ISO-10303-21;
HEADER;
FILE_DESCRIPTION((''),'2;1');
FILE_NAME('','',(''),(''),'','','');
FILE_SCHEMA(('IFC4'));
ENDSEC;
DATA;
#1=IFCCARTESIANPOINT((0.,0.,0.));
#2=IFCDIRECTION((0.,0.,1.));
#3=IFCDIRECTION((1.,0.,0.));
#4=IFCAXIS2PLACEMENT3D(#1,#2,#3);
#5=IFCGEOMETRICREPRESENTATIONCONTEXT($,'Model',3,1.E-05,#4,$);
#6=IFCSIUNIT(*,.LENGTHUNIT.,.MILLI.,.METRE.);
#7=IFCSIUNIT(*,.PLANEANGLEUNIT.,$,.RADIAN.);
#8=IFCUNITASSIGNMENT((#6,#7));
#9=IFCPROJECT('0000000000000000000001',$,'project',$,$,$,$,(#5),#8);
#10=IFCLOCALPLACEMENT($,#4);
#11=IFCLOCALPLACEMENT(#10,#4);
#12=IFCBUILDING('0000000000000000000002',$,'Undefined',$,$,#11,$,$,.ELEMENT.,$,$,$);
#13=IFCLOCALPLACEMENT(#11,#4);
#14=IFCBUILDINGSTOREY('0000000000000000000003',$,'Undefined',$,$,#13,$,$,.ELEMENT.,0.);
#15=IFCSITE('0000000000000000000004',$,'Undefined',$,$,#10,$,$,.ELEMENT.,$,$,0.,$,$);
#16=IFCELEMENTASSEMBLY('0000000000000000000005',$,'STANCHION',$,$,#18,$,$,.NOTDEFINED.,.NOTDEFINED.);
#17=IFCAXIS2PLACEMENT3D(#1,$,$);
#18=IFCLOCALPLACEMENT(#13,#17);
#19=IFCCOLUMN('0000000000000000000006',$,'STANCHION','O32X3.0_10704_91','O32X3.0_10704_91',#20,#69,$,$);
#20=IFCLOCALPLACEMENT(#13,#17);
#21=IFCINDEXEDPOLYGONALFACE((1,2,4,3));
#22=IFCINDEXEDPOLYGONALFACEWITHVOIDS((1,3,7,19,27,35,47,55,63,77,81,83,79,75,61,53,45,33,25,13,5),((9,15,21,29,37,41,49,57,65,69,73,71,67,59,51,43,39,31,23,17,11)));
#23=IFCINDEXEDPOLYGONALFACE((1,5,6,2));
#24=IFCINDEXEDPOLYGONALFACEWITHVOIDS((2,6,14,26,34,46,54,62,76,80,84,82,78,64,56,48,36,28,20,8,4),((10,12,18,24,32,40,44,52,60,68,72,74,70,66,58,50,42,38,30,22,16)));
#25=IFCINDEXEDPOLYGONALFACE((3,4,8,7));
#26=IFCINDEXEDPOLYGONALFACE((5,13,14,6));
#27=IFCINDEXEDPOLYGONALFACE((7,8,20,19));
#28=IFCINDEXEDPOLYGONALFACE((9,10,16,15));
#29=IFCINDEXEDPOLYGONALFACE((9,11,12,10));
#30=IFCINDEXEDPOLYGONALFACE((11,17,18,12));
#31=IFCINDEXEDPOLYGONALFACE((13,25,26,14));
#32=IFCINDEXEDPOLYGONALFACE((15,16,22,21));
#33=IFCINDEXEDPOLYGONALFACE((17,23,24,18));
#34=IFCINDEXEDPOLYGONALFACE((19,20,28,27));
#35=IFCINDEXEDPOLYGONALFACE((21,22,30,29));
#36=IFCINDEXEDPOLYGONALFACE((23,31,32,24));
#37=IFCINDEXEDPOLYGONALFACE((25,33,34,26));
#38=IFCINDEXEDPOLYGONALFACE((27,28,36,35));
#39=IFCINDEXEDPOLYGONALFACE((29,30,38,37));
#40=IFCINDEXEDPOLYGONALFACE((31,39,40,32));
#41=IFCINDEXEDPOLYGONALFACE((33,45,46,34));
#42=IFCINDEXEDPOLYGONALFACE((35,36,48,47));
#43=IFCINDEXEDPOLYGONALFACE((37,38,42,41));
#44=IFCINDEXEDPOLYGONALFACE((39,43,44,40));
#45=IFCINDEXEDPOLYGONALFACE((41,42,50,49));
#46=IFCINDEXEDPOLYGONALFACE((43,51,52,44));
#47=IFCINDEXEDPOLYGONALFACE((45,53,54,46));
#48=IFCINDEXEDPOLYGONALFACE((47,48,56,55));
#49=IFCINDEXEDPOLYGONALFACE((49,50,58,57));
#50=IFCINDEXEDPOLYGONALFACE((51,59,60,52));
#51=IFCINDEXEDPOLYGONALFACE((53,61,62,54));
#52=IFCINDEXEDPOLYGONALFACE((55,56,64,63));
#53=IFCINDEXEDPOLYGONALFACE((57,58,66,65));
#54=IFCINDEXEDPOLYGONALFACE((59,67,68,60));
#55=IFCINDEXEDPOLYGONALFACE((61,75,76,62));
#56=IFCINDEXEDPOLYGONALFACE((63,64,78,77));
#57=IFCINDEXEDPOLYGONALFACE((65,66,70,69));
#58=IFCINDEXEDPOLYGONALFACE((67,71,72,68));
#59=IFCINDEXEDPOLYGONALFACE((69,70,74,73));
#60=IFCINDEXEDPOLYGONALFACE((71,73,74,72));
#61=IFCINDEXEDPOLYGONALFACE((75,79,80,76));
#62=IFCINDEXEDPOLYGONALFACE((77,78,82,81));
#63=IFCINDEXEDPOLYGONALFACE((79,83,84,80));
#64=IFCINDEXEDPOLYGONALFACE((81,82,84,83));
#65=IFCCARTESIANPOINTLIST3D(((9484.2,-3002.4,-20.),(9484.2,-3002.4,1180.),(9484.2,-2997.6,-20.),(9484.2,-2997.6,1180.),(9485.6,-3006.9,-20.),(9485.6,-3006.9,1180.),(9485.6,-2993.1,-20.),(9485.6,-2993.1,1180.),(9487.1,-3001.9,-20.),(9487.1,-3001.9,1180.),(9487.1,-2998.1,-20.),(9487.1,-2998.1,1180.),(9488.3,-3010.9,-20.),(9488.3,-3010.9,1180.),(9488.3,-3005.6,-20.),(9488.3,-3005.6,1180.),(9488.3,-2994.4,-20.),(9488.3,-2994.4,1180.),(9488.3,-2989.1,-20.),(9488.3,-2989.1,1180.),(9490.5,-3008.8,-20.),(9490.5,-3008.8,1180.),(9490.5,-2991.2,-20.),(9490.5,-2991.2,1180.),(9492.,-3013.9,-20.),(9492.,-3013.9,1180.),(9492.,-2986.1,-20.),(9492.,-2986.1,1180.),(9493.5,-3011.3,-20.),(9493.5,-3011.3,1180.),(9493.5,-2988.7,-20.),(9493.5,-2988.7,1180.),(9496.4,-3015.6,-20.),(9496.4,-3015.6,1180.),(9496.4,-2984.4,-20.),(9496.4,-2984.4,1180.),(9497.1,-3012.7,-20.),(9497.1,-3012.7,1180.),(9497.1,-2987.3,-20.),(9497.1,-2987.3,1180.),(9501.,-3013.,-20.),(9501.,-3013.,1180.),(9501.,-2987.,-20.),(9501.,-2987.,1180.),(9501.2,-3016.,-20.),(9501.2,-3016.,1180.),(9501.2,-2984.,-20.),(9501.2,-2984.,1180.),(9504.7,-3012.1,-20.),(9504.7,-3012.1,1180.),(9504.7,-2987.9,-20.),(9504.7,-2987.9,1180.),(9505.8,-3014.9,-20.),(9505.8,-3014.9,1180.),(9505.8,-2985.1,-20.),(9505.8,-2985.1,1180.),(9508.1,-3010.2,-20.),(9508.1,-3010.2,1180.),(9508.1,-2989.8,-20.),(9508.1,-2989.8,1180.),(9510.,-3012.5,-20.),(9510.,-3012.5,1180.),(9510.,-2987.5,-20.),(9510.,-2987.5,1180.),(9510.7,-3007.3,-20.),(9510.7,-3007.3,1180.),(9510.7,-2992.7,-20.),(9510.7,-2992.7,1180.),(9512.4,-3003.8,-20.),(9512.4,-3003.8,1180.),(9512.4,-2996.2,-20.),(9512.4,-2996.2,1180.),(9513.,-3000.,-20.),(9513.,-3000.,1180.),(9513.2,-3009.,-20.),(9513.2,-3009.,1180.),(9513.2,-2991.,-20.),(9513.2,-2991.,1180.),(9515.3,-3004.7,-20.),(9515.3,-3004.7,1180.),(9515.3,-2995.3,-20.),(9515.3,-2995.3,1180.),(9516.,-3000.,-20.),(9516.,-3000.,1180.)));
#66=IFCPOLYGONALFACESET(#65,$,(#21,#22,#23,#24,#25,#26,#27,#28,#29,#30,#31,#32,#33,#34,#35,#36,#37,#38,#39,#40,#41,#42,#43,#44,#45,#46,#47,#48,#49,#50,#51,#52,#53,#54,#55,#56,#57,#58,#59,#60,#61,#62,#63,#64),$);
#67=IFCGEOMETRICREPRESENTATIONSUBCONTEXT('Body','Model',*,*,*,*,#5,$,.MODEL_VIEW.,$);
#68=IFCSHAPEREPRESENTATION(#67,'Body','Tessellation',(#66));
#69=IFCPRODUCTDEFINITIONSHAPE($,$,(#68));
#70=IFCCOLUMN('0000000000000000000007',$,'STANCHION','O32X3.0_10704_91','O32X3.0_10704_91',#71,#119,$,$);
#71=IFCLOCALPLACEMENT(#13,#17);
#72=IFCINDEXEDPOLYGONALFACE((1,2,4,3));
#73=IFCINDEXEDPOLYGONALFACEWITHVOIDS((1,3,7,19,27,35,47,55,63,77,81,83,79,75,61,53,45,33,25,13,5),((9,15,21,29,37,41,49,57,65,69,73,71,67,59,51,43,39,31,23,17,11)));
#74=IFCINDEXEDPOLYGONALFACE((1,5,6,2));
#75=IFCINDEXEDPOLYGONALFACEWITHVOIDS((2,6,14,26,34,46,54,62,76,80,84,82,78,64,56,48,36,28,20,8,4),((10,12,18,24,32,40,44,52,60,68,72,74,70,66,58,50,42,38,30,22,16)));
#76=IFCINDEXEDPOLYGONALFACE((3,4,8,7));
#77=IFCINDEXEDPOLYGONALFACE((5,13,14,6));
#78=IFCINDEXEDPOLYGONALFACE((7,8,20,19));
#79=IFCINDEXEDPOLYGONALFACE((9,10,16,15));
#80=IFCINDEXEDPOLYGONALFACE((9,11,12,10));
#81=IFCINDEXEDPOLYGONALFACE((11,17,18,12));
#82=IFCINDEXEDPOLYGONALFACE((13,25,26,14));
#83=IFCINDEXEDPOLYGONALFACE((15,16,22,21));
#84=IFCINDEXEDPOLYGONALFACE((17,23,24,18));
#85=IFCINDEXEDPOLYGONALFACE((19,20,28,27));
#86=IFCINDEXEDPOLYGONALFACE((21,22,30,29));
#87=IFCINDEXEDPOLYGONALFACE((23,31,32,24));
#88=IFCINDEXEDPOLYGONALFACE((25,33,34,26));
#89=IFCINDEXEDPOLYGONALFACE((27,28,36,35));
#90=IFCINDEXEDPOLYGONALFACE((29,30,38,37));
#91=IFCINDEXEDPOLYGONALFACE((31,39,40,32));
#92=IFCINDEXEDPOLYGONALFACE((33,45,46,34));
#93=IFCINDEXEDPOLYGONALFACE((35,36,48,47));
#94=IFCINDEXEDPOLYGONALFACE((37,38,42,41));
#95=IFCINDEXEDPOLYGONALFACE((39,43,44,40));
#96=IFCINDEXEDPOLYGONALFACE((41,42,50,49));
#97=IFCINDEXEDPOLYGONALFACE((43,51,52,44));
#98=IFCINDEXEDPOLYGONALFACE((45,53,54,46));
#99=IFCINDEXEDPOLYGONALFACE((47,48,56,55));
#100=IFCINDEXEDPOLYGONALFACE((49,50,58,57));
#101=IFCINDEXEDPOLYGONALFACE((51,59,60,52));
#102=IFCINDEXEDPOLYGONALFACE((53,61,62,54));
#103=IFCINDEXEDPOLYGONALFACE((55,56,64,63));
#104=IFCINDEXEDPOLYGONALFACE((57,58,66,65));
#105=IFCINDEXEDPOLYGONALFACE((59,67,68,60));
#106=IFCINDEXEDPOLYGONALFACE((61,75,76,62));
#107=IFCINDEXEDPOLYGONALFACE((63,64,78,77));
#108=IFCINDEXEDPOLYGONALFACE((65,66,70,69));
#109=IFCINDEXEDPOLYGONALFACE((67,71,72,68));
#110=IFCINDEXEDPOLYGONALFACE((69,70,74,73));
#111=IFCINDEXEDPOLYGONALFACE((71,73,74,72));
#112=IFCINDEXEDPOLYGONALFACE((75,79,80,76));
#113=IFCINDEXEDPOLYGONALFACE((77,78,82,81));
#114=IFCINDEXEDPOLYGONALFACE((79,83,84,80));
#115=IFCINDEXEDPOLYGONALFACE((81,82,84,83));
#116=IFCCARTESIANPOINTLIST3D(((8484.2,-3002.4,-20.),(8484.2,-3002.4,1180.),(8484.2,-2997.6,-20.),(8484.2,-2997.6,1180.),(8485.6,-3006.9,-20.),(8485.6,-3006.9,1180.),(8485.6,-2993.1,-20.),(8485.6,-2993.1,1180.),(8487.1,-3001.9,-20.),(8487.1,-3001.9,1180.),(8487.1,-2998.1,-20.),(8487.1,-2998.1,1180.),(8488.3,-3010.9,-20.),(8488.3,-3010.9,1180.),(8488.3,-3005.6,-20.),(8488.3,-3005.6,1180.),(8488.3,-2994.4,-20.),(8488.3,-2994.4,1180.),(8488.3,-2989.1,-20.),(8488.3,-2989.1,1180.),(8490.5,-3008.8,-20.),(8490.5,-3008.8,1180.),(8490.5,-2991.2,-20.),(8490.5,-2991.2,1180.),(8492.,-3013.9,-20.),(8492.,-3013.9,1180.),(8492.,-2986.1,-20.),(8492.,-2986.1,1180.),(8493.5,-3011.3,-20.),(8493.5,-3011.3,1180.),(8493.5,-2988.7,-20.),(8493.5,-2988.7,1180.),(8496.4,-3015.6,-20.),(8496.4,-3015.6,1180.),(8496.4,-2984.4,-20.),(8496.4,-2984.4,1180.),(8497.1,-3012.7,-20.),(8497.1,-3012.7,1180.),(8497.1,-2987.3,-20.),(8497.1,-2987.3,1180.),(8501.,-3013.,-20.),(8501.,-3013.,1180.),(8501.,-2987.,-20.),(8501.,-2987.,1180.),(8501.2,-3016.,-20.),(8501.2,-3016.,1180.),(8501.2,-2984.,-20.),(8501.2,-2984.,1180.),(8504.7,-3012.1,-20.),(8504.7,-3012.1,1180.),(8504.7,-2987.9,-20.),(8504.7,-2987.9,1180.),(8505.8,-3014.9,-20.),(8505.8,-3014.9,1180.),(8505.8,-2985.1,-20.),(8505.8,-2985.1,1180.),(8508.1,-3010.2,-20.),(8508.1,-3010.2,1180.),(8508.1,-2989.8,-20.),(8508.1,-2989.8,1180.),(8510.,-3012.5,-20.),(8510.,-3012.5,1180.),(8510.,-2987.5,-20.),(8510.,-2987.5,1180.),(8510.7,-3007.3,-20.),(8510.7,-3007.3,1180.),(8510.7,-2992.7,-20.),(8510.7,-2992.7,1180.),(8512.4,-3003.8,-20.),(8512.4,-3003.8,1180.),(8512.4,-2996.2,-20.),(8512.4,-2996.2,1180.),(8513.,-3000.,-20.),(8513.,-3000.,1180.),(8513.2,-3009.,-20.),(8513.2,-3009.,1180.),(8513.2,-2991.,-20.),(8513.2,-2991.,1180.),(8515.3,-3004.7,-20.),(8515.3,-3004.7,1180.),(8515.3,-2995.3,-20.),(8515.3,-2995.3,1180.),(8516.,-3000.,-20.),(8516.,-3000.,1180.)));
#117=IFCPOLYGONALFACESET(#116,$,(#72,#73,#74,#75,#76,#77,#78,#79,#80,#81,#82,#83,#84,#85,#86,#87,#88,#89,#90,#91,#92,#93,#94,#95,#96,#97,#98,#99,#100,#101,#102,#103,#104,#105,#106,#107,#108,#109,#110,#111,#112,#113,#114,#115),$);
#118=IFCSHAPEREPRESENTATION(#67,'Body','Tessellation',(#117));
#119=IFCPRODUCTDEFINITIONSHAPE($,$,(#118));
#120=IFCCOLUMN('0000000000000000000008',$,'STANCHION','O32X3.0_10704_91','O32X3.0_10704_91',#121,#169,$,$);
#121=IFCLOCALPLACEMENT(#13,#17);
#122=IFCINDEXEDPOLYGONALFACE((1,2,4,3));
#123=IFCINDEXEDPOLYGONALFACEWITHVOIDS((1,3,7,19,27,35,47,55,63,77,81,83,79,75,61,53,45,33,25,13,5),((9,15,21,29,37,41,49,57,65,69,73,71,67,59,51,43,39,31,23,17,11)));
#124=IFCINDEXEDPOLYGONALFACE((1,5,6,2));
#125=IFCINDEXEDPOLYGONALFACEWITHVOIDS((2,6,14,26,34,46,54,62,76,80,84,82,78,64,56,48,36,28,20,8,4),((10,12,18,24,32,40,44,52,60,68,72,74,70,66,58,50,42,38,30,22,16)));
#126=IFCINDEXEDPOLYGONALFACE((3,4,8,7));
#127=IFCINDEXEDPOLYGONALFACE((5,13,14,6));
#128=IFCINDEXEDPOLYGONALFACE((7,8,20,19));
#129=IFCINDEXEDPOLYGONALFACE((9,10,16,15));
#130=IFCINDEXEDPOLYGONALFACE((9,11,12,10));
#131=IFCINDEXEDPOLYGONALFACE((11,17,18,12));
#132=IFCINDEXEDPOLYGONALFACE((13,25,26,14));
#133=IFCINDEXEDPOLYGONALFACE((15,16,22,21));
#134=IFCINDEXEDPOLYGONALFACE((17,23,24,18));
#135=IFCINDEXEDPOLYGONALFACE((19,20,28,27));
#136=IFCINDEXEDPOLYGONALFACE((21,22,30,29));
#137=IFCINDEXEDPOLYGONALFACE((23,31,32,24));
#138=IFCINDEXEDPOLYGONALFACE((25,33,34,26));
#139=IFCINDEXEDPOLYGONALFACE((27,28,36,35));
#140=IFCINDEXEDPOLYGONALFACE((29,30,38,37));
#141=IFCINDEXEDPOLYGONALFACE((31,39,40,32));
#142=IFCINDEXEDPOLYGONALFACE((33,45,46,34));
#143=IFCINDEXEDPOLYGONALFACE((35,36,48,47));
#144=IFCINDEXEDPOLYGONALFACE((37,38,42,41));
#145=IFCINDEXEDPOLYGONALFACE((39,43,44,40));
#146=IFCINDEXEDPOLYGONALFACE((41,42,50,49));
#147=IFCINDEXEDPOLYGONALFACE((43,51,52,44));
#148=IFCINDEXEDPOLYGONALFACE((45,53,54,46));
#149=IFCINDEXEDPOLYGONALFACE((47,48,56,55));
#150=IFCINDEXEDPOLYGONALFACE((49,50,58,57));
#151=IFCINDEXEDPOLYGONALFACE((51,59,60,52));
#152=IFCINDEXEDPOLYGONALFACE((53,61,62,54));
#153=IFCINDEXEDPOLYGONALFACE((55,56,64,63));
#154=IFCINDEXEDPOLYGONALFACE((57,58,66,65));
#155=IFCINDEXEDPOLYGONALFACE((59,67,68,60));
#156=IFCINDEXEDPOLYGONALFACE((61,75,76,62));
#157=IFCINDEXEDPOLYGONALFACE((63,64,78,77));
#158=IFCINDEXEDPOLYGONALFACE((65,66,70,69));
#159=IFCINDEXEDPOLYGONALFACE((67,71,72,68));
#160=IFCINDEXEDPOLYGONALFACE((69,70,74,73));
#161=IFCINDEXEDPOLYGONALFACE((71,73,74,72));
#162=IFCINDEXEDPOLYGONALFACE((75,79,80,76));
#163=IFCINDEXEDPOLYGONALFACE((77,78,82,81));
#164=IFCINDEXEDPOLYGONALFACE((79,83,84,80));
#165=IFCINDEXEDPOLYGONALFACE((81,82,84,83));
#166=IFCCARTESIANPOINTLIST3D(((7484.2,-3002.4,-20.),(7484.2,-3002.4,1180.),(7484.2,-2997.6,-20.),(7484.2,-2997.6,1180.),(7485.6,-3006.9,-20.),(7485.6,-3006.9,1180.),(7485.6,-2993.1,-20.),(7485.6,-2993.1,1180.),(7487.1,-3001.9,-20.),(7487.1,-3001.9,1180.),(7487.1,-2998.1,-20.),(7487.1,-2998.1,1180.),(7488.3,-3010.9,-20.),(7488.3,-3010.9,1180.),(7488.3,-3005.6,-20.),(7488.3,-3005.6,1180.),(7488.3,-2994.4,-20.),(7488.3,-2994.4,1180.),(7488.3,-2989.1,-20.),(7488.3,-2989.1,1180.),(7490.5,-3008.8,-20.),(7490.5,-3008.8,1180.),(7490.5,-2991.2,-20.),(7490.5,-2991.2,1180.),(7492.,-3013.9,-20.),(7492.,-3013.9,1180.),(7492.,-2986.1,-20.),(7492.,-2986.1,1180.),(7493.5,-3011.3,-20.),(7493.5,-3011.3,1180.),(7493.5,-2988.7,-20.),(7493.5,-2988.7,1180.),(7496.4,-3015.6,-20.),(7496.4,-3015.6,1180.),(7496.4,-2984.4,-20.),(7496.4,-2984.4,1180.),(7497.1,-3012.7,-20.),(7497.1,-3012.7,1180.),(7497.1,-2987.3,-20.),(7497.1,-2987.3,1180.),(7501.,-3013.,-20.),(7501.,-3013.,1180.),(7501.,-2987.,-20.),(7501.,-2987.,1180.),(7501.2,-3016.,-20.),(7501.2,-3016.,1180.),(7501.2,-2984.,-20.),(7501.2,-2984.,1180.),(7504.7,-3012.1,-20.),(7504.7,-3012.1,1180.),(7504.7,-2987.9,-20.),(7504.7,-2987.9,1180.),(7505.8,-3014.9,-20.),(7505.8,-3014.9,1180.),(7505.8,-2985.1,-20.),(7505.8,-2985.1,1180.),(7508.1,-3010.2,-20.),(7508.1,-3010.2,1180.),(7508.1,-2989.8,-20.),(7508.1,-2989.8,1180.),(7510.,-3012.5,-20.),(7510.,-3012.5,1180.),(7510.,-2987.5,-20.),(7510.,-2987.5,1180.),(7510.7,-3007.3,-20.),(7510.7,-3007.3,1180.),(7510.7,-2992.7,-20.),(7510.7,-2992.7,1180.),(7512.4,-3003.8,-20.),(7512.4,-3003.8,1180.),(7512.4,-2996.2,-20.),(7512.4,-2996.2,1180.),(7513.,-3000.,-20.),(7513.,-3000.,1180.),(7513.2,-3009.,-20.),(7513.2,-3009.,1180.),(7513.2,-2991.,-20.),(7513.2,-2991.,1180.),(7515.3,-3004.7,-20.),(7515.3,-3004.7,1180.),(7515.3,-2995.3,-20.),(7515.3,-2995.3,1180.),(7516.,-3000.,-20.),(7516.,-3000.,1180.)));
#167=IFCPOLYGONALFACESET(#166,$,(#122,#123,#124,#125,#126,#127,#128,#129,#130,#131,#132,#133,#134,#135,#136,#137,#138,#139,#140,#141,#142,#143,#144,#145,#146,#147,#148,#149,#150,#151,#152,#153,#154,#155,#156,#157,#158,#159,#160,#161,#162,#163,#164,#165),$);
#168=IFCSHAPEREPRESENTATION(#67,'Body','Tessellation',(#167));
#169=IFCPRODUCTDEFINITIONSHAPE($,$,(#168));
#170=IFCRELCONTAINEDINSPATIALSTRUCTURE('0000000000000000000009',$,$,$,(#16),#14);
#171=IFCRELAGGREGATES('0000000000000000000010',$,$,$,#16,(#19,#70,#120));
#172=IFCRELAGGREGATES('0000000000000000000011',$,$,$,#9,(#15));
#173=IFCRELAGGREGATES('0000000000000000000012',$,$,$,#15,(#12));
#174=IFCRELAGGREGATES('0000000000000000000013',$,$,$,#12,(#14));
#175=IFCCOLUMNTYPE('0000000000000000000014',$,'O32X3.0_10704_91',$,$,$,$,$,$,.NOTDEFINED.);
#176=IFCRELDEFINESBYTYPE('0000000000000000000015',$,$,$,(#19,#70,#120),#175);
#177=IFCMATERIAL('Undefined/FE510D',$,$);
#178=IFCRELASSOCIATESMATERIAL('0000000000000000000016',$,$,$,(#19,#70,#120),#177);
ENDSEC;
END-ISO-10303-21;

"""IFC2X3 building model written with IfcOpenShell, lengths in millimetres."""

from ifc_helpers import new_model, si_unit, frame, origin_with_axes, origin_2d_with_axis, place, context, subcontext, project, spatial, hollow_circle, extrude, material, type_object, element, aggregate, save


model = new_model("IFC2X3")

# Units and contexts
model_context = context("Model", 3, precision=1e-05, world=origin_with_axes())
body_context = subcontext(model_context, "Body", "Model", "MODEL_VIEW")
ifc_project = project(units=[si_unit("LENGTHUNIT", "METRE", prefix="MILLI"), si_unit("PLANEANGLEUNIT", "RADIAN")], contexts=[model_context])

# Site, building, storey
site_placement = place(None, origin_with_axes())
site = spatial("IfcSite", under=ifc_project, at=site_placement, Name="Undefined", CompositionType="ELEMENT", RefElevation=0.0)
building_placement = place(site_placement, origin_with_axes())
building = spatial("IfcBuilding", under=site, at=building_placement, Name="Undefined", CompositionType="ELEMENT")
storey_placement = place(building_placement, origin_with_axes())
storey = spatial("IfcBuildingStorey", under=building, at=storey_placement, Name="Undefined", CompositionType="ELEMENT", Elevation=0.0)

# Element assembly, columns
assembly_1_placement = place(storey_placement, origin_with_axes())
assembly_1 = element("IfcElementAssembly", 1, at=assembly_1_placement, inside=storey, Name="STANCHION", AssemblyPlace="NOTDEFINED", PredefinedType="NOTDEFINED")
ifc_material_1 = material(Name="Undefined/FE510D")
column_type_1 = type_object("IfcColumnType", Name="O32X3.0_10704_91", PredefinedType="NOTDEFINED")
column_1_placement = place(assembly_1_placement, frame((9500.0, -3000.0, -20.0), z_axis=(0.0, 0.0, 1.0), x_axis=(0.0, -1.0, 0.0)))
column_1 = element("IfcColumn", 2, at=column_1_placement, type_object=column_type_1, material=ifc_material_1, Name="STANCHION", Description="O32X3.0_10704_91", ObjectType="O32X3.0_10704_91", context=body_context, shape_type="SweptSolid", body=[
    extrude(hollow_circle(Radius=16.0, WallThickness=3.0, at=origin_2d_with_axis()), frame((0.0, 0.0, 1200.0), z_axis=(0.0, 0.0, -1.0), x_axis=(0.0, 1.0, 0.0)), (0.0, 0.0, 1.0), 1200.0),
])
column_2_placement = place(assembly_1_placement, frame((8500.0, -3000.0, -20.0), z_axis=(0.0, 0.0, 1.0), x_axis=(0.0, -1.0, 0.0)))
column_2 = element("IfcColumn", 3, at=column_2_placement, type_object=column_type_1, material=ifc_material_1, Name="STANCHION", Description="O32X3.0_10704_91", ObjectType="O32X3.0_10704_91", context=body_context, shape_type="SweptSolid", body=[
    extrude(hollow_circle(Radius=16.0, WallThickness=3.0, at=origin_2d_with_axis()), frame((0.0, 0.0, 1200.0), z_axis=(0.0, 0.0, -1.0), x_axis=(0.0, 1.0, 0.0)), (0.0, 0.0, 1.0), 1200.0),
])
column_3_placement = place(assembly_1_placement, frame((7500.0, -3000.0, -20.0), z_axis=(0.0, 0.0, 1.0), x_axis=(0.0, -1.0, 0.0)))
column_3 = element("IfcColumn", 4, at=column_3_placement, type_object=column_type_1, material=ifc_material_1, Name="STANCHION", Description="O32X3.0_10704_91", ObjectType="O32X3.0_10704_91", context=body_context, shape_type="SweptSolid", body=[
    extrude(hollow_circle(Radius=16.0, WallThickness=3.0, at=origin_2d_with_axis()), frame((0.0, 0.0, 1200.0), z_axis=(0.0, 0.0, -1.0), x_axis=(0.0, 1.0, 0.0)), (0.0, 0.0, 1.0), 1200.0),
])
aggregate(assembly_1, [column_1, column_2, column_3])

save(model, "model.ifc")
